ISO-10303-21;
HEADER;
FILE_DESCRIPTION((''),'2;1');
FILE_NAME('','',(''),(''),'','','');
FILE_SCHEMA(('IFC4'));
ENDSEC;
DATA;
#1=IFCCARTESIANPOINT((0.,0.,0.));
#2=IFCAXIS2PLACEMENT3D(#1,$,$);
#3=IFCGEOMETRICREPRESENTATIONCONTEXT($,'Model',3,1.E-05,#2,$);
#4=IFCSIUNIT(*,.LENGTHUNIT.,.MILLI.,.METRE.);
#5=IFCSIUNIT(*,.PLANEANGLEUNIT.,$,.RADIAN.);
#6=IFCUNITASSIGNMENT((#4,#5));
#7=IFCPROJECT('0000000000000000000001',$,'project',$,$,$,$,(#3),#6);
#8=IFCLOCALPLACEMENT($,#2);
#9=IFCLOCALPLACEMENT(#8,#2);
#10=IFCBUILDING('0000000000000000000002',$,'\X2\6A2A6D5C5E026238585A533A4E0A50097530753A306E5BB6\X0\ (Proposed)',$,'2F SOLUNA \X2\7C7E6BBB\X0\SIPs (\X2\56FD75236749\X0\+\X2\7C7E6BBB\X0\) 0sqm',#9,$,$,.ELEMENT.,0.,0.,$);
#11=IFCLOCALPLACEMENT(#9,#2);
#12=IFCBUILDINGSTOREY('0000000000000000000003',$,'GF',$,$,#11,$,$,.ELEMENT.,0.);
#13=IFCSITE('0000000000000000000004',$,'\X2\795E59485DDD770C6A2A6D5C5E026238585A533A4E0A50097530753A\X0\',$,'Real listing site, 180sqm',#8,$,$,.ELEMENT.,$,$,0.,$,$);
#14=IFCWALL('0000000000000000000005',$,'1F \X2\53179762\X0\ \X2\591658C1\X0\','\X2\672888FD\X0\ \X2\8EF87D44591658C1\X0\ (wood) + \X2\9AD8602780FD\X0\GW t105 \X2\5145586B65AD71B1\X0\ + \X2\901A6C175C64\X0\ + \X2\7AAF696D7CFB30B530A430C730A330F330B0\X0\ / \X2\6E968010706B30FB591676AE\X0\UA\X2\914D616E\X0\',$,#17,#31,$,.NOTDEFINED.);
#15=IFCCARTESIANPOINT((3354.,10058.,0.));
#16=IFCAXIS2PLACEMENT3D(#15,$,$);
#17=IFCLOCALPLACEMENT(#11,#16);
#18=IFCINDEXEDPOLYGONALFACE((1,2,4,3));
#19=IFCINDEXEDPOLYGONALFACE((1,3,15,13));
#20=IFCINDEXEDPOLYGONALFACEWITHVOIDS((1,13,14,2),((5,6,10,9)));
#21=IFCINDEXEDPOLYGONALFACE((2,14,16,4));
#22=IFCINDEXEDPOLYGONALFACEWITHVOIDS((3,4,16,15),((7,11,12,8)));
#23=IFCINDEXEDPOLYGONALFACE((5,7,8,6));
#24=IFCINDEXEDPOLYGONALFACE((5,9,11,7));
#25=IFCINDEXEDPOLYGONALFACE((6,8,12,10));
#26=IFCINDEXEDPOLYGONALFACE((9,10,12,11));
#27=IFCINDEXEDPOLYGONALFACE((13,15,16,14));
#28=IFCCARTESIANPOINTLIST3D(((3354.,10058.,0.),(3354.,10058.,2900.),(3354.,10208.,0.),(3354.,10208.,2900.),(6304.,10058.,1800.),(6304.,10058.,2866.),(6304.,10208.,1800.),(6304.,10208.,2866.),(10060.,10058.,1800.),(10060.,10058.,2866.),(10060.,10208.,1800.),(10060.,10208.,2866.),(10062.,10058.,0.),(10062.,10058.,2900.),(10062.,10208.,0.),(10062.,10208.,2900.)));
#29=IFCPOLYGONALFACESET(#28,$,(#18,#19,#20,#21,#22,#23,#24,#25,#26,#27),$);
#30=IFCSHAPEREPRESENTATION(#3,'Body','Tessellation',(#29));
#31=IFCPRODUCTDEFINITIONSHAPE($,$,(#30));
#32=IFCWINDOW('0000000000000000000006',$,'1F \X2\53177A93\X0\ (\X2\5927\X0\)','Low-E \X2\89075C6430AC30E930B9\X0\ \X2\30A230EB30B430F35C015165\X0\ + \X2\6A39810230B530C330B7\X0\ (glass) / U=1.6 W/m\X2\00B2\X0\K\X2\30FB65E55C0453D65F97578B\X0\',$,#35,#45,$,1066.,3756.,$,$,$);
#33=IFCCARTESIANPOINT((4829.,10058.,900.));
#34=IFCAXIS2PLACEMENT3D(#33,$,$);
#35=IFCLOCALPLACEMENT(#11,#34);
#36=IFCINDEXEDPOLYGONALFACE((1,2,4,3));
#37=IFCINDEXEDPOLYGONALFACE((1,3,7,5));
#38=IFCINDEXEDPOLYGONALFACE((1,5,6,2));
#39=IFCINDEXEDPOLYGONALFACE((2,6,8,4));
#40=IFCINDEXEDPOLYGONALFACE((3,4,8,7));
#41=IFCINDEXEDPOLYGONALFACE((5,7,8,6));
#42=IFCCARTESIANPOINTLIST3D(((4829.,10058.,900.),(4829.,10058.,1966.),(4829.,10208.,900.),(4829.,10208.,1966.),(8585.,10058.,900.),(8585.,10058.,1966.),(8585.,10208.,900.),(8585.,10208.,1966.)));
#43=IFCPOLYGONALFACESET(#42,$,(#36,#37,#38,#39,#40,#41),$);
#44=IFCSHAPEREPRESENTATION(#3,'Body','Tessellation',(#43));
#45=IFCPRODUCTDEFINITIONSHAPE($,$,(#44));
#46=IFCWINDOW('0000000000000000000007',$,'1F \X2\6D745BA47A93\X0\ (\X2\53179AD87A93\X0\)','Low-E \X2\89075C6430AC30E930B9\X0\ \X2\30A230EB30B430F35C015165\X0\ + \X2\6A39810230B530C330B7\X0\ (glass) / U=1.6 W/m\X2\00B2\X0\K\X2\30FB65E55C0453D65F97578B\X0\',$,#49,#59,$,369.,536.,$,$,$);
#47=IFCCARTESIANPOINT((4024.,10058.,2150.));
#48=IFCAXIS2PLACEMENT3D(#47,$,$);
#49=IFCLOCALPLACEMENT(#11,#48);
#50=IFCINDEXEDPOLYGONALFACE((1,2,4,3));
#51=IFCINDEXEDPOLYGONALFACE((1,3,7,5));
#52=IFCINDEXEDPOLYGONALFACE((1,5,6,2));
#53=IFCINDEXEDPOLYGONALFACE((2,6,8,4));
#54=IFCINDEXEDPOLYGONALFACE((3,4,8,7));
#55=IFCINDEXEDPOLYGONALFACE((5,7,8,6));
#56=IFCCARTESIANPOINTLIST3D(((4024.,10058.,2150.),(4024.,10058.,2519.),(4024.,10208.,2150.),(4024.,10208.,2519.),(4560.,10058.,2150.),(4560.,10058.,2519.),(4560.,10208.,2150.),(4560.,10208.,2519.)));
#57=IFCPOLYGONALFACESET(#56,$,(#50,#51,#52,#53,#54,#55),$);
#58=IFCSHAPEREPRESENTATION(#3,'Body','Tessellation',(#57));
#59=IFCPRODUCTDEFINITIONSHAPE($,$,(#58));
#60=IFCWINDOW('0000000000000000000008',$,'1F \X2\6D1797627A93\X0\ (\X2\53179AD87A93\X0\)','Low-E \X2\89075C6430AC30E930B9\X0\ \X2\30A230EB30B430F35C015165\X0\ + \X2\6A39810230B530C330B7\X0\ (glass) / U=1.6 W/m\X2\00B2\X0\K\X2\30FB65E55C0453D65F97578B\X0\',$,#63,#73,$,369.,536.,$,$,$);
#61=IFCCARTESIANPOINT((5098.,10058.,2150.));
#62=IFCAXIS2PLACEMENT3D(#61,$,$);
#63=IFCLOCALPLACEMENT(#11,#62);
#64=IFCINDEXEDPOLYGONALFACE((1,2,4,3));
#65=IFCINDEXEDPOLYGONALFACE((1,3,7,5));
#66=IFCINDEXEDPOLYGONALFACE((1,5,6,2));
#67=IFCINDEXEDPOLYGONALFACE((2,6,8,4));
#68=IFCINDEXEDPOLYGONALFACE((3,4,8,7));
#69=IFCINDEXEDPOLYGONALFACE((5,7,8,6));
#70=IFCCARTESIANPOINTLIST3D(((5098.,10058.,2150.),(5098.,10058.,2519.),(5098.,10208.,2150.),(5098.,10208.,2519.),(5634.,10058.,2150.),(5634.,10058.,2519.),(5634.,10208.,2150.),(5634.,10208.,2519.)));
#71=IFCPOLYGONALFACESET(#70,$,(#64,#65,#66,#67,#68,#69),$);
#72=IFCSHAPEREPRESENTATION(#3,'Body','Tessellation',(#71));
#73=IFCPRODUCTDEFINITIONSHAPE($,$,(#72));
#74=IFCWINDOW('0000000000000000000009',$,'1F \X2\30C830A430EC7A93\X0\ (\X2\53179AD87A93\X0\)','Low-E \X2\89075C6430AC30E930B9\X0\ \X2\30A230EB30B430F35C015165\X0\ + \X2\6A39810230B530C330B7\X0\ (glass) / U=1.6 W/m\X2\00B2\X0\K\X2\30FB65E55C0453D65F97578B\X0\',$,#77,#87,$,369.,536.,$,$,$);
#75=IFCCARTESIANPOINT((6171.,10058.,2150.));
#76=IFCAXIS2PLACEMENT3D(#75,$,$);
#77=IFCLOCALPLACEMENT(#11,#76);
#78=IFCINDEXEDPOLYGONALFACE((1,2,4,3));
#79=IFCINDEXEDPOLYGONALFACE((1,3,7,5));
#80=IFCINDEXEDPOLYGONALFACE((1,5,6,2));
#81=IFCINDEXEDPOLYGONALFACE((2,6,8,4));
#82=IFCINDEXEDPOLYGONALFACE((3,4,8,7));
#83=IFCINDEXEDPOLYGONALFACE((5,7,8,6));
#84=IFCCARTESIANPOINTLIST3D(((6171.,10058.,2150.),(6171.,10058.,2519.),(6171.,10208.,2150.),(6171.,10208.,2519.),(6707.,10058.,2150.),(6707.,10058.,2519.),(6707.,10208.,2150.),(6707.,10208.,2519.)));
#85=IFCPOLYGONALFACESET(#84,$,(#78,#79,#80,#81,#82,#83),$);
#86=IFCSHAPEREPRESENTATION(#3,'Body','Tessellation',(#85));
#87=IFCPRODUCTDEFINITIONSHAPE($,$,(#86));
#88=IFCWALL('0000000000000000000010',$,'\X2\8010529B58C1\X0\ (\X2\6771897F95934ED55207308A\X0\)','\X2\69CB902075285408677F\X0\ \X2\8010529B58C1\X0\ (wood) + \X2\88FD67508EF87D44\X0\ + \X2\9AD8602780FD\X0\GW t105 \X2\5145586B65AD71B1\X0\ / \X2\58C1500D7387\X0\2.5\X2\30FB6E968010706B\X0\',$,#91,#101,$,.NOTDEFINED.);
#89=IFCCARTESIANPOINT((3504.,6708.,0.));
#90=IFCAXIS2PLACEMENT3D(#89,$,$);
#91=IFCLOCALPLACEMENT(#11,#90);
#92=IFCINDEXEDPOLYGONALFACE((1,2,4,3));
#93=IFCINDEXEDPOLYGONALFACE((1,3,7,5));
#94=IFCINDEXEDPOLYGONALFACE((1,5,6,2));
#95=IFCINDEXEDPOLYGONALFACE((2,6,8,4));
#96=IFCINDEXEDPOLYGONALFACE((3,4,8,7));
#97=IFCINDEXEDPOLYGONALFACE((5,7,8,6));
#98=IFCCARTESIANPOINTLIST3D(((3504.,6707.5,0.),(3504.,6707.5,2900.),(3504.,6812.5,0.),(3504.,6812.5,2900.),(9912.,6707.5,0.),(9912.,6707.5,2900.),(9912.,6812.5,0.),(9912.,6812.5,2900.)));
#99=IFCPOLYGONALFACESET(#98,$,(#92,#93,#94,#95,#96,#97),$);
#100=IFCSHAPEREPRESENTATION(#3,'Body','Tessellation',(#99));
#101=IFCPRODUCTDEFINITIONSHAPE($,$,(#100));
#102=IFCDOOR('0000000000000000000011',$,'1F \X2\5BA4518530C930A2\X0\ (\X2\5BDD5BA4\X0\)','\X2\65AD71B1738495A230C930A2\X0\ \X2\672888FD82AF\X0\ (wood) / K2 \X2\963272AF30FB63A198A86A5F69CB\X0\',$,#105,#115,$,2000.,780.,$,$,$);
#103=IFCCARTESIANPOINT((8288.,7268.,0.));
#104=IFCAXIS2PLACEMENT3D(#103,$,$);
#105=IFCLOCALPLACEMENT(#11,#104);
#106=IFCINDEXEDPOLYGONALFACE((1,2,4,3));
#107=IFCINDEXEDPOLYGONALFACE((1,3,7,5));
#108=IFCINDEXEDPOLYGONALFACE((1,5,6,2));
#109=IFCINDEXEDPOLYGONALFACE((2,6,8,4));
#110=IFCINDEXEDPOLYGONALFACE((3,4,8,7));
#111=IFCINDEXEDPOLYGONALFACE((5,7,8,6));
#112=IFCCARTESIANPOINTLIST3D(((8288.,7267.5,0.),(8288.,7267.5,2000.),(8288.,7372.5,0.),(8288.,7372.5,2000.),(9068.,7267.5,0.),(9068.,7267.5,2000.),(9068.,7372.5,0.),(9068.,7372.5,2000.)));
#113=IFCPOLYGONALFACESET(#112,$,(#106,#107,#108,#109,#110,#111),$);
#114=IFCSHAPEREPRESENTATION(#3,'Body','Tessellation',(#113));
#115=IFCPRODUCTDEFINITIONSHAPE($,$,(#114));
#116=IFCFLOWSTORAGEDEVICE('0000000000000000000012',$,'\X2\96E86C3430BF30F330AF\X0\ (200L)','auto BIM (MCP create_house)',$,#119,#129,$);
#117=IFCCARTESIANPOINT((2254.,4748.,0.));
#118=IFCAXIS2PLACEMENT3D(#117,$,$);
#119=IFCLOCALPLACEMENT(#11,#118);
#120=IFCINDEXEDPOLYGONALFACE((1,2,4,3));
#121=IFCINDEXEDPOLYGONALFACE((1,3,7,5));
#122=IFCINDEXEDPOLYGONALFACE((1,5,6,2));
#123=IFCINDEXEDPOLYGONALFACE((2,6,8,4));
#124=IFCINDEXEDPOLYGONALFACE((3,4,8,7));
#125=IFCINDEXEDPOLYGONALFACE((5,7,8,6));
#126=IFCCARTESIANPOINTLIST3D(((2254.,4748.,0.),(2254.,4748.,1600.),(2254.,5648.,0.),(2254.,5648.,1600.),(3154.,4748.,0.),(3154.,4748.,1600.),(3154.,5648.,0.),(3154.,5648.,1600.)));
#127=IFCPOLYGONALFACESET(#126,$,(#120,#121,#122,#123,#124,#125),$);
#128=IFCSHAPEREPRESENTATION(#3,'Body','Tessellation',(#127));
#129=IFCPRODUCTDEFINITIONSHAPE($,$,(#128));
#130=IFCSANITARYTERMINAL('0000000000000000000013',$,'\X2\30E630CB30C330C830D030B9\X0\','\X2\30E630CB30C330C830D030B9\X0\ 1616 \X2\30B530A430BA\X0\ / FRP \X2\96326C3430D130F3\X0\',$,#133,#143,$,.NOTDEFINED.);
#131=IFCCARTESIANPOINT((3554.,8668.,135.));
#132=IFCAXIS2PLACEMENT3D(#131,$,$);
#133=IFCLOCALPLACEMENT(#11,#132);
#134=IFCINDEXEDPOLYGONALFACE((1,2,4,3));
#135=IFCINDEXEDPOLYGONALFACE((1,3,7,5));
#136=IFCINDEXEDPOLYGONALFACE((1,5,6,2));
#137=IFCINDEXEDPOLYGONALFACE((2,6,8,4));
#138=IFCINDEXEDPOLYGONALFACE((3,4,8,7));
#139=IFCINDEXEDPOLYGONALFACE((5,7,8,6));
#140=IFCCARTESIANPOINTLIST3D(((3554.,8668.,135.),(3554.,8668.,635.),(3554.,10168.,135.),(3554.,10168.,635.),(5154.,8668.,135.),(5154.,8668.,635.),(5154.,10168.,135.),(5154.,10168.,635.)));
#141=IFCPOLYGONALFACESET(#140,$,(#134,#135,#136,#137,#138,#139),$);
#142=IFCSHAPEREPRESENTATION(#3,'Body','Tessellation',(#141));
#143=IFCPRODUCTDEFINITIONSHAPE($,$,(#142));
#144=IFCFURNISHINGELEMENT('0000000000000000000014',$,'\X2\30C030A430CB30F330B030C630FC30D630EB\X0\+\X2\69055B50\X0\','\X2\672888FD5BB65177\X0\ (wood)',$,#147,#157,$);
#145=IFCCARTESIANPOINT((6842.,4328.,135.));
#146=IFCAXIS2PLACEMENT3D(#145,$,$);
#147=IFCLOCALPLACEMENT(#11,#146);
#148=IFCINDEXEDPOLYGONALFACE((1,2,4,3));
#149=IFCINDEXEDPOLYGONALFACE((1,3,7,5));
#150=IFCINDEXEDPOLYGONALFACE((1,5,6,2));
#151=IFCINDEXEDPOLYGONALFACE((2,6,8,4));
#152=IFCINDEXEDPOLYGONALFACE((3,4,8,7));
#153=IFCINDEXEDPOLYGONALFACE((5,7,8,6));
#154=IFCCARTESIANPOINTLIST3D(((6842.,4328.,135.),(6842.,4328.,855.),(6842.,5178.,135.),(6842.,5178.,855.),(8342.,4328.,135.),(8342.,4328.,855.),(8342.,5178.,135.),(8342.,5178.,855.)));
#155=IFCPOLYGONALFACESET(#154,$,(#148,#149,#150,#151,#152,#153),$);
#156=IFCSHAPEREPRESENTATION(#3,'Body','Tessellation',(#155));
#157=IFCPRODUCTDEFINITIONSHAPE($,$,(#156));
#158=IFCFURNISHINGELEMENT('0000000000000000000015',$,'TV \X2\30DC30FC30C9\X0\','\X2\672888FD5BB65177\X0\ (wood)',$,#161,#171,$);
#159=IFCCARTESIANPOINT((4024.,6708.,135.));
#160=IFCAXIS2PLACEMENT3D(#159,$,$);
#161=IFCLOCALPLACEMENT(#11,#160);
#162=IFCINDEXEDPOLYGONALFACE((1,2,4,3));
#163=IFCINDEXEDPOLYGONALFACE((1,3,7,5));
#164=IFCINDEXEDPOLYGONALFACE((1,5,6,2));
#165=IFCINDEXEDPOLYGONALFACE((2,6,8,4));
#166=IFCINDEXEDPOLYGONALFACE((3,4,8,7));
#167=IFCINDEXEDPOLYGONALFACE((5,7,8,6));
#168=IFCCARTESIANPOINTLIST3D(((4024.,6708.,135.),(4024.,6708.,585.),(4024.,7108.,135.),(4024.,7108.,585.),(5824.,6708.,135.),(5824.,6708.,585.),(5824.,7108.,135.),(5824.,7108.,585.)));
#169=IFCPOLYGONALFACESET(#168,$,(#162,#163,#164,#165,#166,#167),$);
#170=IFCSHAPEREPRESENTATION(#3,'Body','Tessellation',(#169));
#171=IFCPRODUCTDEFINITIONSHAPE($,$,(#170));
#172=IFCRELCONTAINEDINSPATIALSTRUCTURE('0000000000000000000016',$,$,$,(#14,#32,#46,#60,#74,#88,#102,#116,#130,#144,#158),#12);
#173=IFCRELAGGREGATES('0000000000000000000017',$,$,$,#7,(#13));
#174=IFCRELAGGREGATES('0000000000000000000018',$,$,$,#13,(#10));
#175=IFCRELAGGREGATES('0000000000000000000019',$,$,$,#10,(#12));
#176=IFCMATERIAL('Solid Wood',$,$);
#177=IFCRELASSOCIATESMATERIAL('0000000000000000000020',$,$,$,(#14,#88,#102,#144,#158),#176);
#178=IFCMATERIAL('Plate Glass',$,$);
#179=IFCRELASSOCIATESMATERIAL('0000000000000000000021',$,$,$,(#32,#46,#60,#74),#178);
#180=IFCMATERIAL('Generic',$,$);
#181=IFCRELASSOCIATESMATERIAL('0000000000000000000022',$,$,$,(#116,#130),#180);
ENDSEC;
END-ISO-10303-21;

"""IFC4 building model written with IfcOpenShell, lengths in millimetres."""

from ifc_helpers import new_model, si_unit, frame, frame_2d, origin, place, context, project, spatial, rectangle, extrude, material, element, fill, save


model = new_model("IFC4")

# Units and contexts
model_context = context("Model", 3, precision=1e-05, world=origin())
ifc_project = project(units=[si_unit("LENGTHUNIT", "METRE", prefix="MILLI"), si_unit("PLANEANGLEUNIT", "RADIAN")], contexts=[model_context])

# Site, building, storey
site_placement = place(None, origin())
site = spatial("IfcSite", under=ifc_project, at=site_placement, Name="神奈川県横浜市戸塚区上倉田町", ObjectType="Real listing site, 180sqm", CompositionType="ELEMENT", RefElevation=0.0)
building_placement = place(site_placement, origin())
building = spatial("IfcBuilding", under=site, at=building_placement, Name="横浜市戸塚区上倉田町の家 (Proposed)", ObjectType="2F SOLUNA 籾殻SIPs (国産杉+籾殻) 0sqm", CompositionType="ELEMENT", ElevationOfRefHeight=0.0, ElevationOfTerrain=0.0)
storey_placement = place(building_placement, origin())
storey = spatial("IfcBuildingStorey", under=building, at=storey_placement, Name="GF", CompositionType="ELEMENT", Elevation=0.0)

# Wall, openings, windows
ifc_material_1 = material(Name="Solid Wood")
wall_1_placement = place(storey_placement, frame((3354.0, 10058.0, 0.0)))
wall_1 = element("IfcWall", 1, at=wall_1_placement, inside=storey, material=ifc_material_1, Name="1F 北面 外壁", Description="木製 軸組外壁 (wood) + 高性能GW t105 充填断熱 + 通気層 + 窯業系サイディング / 準耐火・外皮UA配慮", PredefinedType="NOTDEFINED", context=model_context, shape_type="SweptSolid", body=[
    extrude(rectangle(XDim=6708.0, YDim=150.0, at=frame_2d((3354.0, 75.0))), frame((3354.0, 10058.0, 0.0)), (0.0, 0.0, 1.0), 2900.0),
])
opening_1_placement = place(storey_placement, frame((4829.0, 10058.0, 900.0)))
opening_1 = element("IfcOpeningElement", 2, at=opening_1_placement, cuts=wall_1, PredefinedType="NOTDEFINED", context=model_context, shape_type="SweptSolid", body=[
    extrude(rectangle(XDim=3756.0, YDim=150.0, at=frame_2d((1878.0, 75.0))), frame((4829.0, 10058.0, 900.0)), (0.0, 0.0, 1.0), 1066.0),
])
opening_2_placement = place(storey_placement, frame((4024.0, 10058.0, 2150.0)))
opening_2 = element("IfcOpeningElement", 3, at=opening_2_placement, cuts=wall_1, PredefinedType="NOTDEFINED", context=model_context, shape_type="SweptSolid", body=[
    extrude(rectangle(XDim=536.0, YDim=150.0, at=frame_2d((268.0, 75.0))), frame((4024.0, 10058.0, 2150.0)), (0.0, 0.0, 1.0), 369.0),
])
opening_3_placement = place(storey_placement, frame((5098.0, 10058.0, 2150.0)))
opening_3 = element("IfcOpeningElement", 4, at=opening_3_placement, cuts=wall_1, PredefinedType="NOTDEFINED", context=model_context, shape_type="SweptSolid", body=[
    extrude(rectangle(XDim=536.0, YDim=150.0, at=frame_2d((268.0, 75.0))), frame((5098.0, 10058.0, 2150.0)), (0.0, 0.0, 1.0), 369.0),
])
opening_4_placement = place(storey_placement, frame((6171.0, 10058.0, 2150.0)))
opening_4 = element("IfcOpeningElement", 5, at=opening_4_placement, cuts=wall_1, PredefinedType="NOTDEFINED", context=model_context, shape_type="SweptSolid", body=[
    extrude(rectangle(XDim=536.0, YDim=150.0, at=frame_2d((268.0, 75.0))), frame((6171.0, 10058.0, 2150.0)), (0.0, 0.0, 1.0), 369.0),
])
ifc_material_2 = material(Name="Plate Glass")
window_1_placement = place(storey_placement, frame((4829.0, 10058.0, 900.0)))
window_1 = element("IfcWindow", 6, at=window_1_placement, inside=storey, material=ifc_material_2, Name="1F 北窓 (大)", Description="Low-E 複層ガラス アルゴン封入 + 樹脂サッシ (glass) / U=1.6 W/m²K・日射取得型", OverallHeight=1066.0, OverallWidth=3756.0, context=model_context, shape_type="SweptSolid", body=[
    extrude(rectangle(XDim=3756.0, YDim=150.0, at=frame_2d((1878.0, 75.0))), frame((4829.0, 10058.0, 900.0)), (0.0, 0.0, 1.0), 1066.0),
])
fill(opening_1, window_1)
window_2_placement = place(storey_placement, frame((4024.0, 10058.0, 2150.0)))
window_2 = element("IfcWindow", 7, at=window_2_placement, inside=storey, material=ifc_material_2, Name="1F 浴室窓 (北高窓)", Description="Low-E 複層ガラス アルゴン封入 + 樹脂サッシ (glass) / U=1.6 W/m²K・日射取得型", OverallHeight=369.0, OverallWidth=536.0, context=model_context, shape_type="SweptSolid", body=[
    extrude(rectangle(XDim=536.0, YDim=150.0, at=frame_2d((268.0, 75.0))), frame((4024.0, 10058.0, 2150.0)), (0.0, 0.0, 1.0), 369.0),
])
fill(opening_2, window_2)
window_3_placement = place(storey_placement, frame((5098.0, 10058.0, 2150.0)))
window_3 = element("IfcWindow", 8, at=window_3_placement, inside=storey, material=ifc_material_2, Name="1F 洗面窓 (北高窓)", Description="Low-E 複層ガラス アルゴン封入 + 樹脂サッシ (glass) / U=1.6 W/m²K・日射取得型", OverallHeight=369.0, OverallWidth=536.0, context=model_context, shape_type="SweptSolid", body=[
    extrude(rectangle(XDim=536.0, YDim=150.0, at=frame_2d((268.0, 75.0))), frame((5098.0, 10058.0, 2150.0)), (0.0, 0.0, 1.0), 369.0),
])
fill(opening_3, window_3)
window_4_placement = place(storey_placement, frame((6171.0, 10058.0, 2150.0)))
window_4 = element("IfcWindow", 9, at=window_4_placement, inside=storey, material=ifc_material_2, Name="1F トイレ窓 (北高窓)", Description="Low-E 複層ガラス アルゴン封入 + 樹脂サッシ (glass) / U=1.6 W/m²K・日射取得型", OverallHeight=369.0, OverallWidth=536.0, context=model_context, shape_type="SweptSolid", body=[
    extrude(rectangle(XDim=536.0, YDim=150.0, at=frame_2d((268.0, 75.0))), frame((6171.0, 10058.0, 2150.0)), (0.0, 0.0, 1.0), 369.0),
])
fill(opening_4, window_4)

# Wall
wall_2_placement = place(storey_placement, frame((3504.0, 6708.0, 0.0)))
element("IfcWall", 10, at=wall_2_placement, inside=storey, material=ifc_material_1, Name="耐力壁 (東西間仕切り)", Description="構造用合板 耐力壁 (wood) + 製材軸組 + 高性能GW t105 充填断熱 / 壁倍率2.5・準耐火", PredefinedType="NOTDEFINED", context=model_context, shape_type="SweptSolid", body=[
    extrude(rectangle(XDim=6408.0, YDim=105.0, at=frame_2d((3204.0, 52.0))), frame((3504.0, 6708.0, 0.0)), (0.0, 0.0, 1.0), 2900.0),
])

# Door
door_1_placement = place(storey_placement, frame((8288.0, 7268.0, 0.0)))
element("IfcDoor", 11, at=door_1_placement, inside=storey, material=ifc_material_1, Name="1F 室内ドア (寝室)", Description="断熱玄関ドア 木製芯 (wood) / K2 防犯・採風機構", OverallHeight=2000.0, OverallWidth=780.0, context=model_context, shape_type="SweptSolid", body=[
    extrude(rectangle(XDim=780.0, YDim=105.0, at=frame_2d((390.0, 52.0))), frame((8288.0, 7268.0, 0.0)), (0.0, 0.0, 1.0), 2000.0),
])

# Flow storage device
ifc_material_3 = material(Name="Generic")
flow_storage_device_placement = place(storey_placement, frame((2254.0, 4748.0, 0.0)))
element("IfcFlowStorageDevice", 12, at=flow_storage_device_placement, inside=storey, material=ifc_material_3, Name="雨水タンク (200L)", Description="auto BIM (MCP create_house)", context=model_context, shape_type="SweptSolid", body=[
    extrude(rectangle(XDim=900.0, YDim=900.0, at=frame_2d((450.0, 450.0))), frame((2254.0, 4748.0, 0.0)), (0.0, 0.0, 1.0), 1600.0),
])

# Sanitary terminal
sanitary_terminal_placement = place(storey_placement, frame((3554.0, 8668.0, 135.0)))
element("IfcSanitaryTerminal", 13, at=sanitary_terminal_placement, inside=storey, material=ifc_material_3, Name="ユニットバス", Description="ユニットバス 1616 サイズ / FRP 防水パン", PredefinedType="NOTDEFINED", context=model_context, shape_type="SweptSolid", body=[
    extrude(rectangle(XDim=1600.0, YDim=1500.0, at=frame_2d((800.0, 750.0))), frame((3554.0, 8668.0, 135.0)), (0.0, 0.0, 1.0), 500.0),
])

# Furnishing elements
furnishing_1_placement = place(storey_placement, frame((6842.0, 4328.0, 135.0)))
element("IfcFurnishingElement", 14, at=furnishing_1_placement, inside=storey, material=ifc_material_1, Name="ダイニングテーブル+椅子", Description="木製家具 (wood)", context=model_context, shape_type="SweptSolid", body=[
    extrude(rectangle(XDim=1500.0, YDim=850.0, at=frame_2d((750.0, 425.0))), frame((6842.0, 4328.0, 135.0)), (0.0, 0.0, 1.0), 720.0),
])
furnishing_2_placement = place(storey_placement, frame((4024.0, 6708.0, 135.0)))
element("IfcFurnishingElement", 15, at=furnishing_2_placement, inside=storey, material=ifc_material_1, Name="TV ボード", Description="木製家具 (wood)", context=model_context, shape_type="SweptSolid", body=[
    extrude(rectangle(XDim=1800.0, YDim=400.0, at=frame_2d((900.0, 200.0))), frame((4024.0, 6708.0, 135.0)), (0.0, 0.0, 1.0), 450.0),
])

save(model, "model.ifc")
